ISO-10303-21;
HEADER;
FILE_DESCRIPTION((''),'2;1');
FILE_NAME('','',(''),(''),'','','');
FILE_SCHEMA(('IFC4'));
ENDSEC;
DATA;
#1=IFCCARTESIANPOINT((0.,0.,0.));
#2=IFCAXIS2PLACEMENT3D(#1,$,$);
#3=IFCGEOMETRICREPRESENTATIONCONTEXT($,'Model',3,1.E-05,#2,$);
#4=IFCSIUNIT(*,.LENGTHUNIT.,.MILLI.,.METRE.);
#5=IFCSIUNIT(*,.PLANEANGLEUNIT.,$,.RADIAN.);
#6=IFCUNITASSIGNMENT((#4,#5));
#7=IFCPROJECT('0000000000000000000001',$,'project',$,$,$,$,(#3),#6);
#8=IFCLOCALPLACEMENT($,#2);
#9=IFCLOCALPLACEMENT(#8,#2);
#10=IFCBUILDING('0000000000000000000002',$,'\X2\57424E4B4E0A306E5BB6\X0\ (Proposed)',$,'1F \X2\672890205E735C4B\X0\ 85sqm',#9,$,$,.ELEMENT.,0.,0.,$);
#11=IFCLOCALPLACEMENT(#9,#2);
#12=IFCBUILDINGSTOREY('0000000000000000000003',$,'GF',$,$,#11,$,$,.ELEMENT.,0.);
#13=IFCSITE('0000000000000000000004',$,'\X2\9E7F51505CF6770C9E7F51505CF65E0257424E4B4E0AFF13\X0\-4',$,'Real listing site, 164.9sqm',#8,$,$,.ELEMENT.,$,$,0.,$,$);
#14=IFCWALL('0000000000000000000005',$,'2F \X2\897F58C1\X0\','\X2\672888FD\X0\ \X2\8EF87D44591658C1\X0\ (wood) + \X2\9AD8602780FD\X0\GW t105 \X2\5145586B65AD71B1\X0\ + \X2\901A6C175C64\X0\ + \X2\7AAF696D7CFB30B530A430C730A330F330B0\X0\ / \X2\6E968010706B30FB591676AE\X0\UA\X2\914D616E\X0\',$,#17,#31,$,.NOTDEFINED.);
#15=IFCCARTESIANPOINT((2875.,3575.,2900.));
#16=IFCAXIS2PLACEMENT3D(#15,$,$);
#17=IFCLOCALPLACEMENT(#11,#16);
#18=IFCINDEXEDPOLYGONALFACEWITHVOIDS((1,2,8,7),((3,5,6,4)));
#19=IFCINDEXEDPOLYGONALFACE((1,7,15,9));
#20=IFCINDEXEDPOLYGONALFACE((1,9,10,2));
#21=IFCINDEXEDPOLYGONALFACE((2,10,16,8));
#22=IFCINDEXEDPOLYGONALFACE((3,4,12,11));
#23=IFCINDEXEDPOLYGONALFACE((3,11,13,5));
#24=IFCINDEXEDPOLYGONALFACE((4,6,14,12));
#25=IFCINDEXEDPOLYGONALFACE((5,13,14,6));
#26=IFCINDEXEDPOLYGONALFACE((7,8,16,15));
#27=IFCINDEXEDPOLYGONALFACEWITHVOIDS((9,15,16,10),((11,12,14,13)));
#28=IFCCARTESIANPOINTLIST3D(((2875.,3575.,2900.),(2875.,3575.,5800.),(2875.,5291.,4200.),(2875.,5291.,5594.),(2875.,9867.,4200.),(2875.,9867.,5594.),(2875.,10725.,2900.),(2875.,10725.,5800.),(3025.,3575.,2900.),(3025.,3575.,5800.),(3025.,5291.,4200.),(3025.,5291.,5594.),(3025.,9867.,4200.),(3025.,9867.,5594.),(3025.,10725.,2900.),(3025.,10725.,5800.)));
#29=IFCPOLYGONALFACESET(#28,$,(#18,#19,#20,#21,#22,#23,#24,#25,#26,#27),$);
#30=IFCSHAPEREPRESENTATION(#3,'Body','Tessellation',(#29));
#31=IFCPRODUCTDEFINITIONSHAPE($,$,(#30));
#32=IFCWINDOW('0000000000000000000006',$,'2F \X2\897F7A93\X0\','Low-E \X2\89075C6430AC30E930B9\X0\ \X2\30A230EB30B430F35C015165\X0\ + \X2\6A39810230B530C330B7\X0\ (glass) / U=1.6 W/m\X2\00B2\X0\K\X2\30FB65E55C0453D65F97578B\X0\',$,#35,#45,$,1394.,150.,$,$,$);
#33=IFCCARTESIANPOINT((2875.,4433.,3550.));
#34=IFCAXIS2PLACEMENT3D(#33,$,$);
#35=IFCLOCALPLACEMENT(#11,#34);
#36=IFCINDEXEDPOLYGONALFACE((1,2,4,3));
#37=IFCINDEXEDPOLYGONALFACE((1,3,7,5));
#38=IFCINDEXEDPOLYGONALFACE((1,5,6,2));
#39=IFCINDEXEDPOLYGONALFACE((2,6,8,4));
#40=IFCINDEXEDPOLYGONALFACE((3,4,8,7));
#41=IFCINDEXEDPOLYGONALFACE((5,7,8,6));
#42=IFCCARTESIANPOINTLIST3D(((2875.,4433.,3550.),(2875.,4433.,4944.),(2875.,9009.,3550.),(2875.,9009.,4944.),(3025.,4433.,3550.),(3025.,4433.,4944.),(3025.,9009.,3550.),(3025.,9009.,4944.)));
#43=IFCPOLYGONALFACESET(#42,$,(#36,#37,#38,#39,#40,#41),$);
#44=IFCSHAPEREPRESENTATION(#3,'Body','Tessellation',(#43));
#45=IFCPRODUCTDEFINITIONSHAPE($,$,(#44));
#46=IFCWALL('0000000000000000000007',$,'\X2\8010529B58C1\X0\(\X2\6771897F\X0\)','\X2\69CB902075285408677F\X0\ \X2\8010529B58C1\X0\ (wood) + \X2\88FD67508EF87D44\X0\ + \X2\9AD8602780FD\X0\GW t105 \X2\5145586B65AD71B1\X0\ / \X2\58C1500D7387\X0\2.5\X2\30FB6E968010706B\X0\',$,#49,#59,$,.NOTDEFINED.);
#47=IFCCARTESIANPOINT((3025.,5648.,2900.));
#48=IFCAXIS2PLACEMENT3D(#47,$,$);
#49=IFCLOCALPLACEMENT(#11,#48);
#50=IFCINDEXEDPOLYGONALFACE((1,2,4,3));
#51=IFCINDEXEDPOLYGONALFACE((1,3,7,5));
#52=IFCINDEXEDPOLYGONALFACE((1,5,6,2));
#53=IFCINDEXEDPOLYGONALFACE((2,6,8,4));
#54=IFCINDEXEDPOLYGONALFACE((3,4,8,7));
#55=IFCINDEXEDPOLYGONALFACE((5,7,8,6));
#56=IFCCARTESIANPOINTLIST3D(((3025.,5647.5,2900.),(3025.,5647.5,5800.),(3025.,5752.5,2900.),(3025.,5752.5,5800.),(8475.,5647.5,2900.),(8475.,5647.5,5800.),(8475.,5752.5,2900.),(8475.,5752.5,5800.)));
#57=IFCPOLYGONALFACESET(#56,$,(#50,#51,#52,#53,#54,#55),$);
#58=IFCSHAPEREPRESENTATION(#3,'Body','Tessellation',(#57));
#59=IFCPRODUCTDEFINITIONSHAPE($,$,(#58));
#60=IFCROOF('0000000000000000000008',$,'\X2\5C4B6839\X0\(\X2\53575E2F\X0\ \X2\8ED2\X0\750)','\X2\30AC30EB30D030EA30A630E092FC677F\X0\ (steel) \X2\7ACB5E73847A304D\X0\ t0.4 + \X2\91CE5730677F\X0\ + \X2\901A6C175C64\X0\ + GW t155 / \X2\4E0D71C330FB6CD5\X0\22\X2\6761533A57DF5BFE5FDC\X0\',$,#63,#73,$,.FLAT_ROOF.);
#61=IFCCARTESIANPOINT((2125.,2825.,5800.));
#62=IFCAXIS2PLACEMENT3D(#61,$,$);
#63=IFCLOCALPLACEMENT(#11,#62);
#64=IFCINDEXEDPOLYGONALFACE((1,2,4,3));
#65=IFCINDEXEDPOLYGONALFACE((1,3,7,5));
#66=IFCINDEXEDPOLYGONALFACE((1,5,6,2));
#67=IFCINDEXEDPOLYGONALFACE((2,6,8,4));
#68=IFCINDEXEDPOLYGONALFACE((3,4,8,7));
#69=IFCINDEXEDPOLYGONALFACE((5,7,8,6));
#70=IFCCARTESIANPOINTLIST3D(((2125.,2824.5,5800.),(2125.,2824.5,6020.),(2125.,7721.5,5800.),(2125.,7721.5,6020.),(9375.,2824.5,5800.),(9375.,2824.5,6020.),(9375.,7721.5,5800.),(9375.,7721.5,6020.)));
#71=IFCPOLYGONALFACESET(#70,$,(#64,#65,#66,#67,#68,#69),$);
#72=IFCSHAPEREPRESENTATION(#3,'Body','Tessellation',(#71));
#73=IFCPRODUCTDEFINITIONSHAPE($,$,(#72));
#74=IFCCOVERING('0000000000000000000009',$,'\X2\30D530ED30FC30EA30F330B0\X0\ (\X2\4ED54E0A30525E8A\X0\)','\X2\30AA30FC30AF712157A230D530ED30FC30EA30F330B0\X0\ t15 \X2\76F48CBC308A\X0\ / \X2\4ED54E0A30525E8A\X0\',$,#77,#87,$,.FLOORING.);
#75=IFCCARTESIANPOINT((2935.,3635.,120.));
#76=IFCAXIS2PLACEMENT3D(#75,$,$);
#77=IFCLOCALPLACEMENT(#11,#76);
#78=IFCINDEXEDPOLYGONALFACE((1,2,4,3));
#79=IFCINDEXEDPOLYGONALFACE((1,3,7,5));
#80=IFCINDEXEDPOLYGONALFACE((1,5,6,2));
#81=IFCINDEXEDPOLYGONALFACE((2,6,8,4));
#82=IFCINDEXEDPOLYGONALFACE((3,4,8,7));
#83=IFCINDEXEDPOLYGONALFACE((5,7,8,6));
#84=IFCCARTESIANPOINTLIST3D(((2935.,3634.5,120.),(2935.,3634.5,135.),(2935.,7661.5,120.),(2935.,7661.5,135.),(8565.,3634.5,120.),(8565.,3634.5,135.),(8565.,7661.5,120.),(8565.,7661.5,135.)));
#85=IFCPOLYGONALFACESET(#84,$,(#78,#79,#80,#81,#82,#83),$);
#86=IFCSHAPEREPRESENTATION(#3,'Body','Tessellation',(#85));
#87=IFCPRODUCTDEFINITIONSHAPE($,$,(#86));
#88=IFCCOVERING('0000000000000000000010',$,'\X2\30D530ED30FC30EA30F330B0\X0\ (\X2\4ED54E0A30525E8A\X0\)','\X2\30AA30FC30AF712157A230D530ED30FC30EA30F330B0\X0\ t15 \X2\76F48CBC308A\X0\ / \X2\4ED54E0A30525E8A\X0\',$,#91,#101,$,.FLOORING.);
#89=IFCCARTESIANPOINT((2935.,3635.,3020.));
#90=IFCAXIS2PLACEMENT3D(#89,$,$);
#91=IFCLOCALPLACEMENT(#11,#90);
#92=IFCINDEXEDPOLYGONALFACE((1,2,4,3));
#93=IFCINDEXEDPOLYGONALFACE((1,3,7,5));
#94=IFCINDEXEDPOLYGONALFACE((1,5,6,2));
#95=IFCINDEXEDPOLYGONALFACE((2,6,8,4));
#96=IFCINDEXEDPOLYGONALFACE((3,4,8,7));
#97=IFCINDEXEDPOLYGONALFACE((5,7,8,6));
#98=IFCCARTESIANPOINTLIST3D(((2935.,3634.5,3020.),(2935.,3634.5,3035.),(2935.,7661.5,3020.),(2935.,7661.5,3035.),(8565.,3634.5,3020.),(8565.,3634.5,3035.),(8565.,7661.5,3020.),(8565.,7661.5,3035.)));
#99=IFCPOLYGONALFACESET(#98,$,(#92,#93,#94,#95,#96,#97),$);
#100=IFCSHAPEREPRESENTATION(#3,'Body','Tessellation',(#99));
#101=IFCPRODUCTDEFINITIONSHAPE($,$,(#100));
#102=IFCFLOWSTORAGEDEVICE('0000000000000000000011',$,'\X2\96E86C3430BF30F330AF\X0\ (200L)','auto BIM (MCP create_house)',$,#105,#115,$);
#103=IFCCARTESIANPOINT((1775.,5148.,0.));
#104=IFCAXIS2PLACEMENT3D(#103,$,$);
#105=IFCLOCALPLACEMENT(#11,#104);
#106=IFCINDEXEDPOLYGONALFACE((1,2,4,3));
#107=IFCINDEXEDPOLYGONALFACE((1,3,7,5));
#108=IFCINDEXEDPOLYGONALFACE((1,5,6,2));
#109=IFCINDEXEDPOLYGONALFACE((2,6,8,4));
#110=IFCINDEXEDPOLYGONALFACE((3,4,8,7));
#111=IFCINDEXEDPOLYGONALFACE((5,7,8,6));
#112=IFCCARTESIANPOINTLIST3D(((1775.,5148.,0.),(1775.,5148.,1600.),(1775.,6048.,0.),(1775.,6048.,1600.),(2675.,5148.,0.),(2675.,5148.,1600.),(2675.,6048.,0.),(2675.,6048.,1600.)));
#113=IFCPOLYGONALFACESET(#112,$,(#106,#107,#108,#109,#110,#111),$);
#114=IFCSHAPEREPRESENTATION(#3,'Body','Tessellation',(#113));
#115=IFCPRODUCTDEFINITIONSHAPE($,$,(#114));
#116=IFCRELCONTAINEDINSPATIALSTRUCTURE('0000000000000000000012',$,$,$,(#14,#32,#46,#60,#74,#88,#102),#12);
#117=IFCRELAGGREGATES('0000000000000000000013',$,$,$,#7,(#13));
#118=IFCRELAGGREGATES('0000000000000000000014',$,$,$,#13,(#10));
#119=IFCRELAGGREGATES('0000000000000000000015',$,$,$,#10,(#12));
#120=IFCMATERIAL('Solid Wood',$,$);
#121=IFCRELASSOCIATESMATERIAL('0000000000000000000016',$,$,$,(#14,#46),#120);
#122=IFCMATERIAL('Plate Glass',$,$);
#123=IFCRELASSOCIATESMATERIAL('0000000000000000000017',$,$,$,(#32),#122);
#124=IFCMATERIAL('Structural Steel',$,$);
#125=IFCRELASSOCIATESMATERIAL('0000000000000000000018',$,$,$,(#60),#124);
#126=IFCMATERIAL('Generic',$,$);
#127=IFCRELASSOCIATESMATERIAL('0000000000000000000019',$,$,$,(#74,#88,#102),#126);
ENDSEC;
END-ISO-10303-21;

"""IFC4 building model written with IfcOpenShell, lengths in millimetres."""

from ifc_helpers import new_model, si_unit, frame, frame_2d, origin, place, context, project, spatial, rectangle, extrude, material, element, fill, save


model = new_model("IFC4")

# Units and contexts
model_context = context("Model", 3, precision=1e-05, world=origin())
ifc_project = project(units=[si_unit("LENGTHUNIT", "METRE", prefix="MILLI"), si_unit("PLANEANGLEUNIT", "RADIAN")], contexts=[model_context])

# Site, building, storey
site_placement = place(None, origin())
site = spatial("IfcSite", under=ifc_project, at=site_placement, Name="鹿児島県鹿児島市坂之上３-4", ObjectType="Real listing site, 164.9sqm", CompositionType="ELEMENT", RefElevation=0.0)
building_placement = place(site_placement, origin())
building = spatial("IfcBuilding", under=site, at=building_placement, Name="坂之上の家 (Proposed)", ObjectType="1F 木造平屋 85sqm", CompositionType="ELEMENT", ElevationOfRefHeight=0.0, ElevationOfTerrain=0.0)
storey_placement = place(building_placement, origin())
storey = spatial("IfcBuildingStorey", under=building, at=storey_placement, Name="GF", CompositionType="ELEMENT", Elevation=0.0)

# Shared definitions
ifc_material_1 = material(Name="Solid Wood")
ifc_material_2 = material(Name="Generic")

# Shared definitions
ifc_material_3 = material(Name="Plate Glass")

# Wall, opening, window
wall_1_placement = place(storey_placement, frame((2875.0, 3575.0, 2900.0)))
wall_1 = element("IfcWall", 1, at=wall_1_placement, inside=storey, material=ifc_material_1, Name="2F 西壁", Description="木製 軸組外壁 (wood) + 高性能GW t105 充填断熱 + 通気層 + 窯業系サイディング / 準耐火・外皮UA配慮", PredefinedType="NOTDEFINED", context=model_context, shape_type="SweptSolid", body=[
    extrude(rectangle(XDim=150.0, YDim=7150.0, at=frame_2d((75.0, 3575.0))), frame((2875.0, 3575.0, 2900.0)), (0.0, 0.0, 1.0), 2900.0),
])
opening_1_placement = place(storey_placement, frame((2875.0, 4433.0, 3550.0)))
opening_1 = element("IfcOpeningElement", 2, at=opening_1_placement, cuts=wall_1, PredefinedType="NOTDEFINED", context=model_context, shape_type="SweptSolid", body=[
    extrude(rectangle(XDim=150.0, YDim=4576.0, at=frame_2d((75.0, 2288.0))), frame((2875.0, 4433.0, 3550.0)), (0.0, 0.0, 1.0), 1394.0),
])
window_1_placement = place(storey_placement, frame((2875.0, 4433.0, 3550.0)))
window_1 = element("IfcWindow", 3, at=window_1_placement, inside=storey, material=ifc_material_3, Name="2F 西窓", Description="Low-E 複層ガラス アルゴン封入 + 樹脂サッシ (glass) / U=1.6 W/m²K・日射取得型", OverallHeight=1394.0, OverallWidth=150.0, context=model_context, shape_type="SweptSolid", body=[
    extrude(rectangle(XDim=150.0, YDim=4576.0, at=frame_2d((75.0, 2288.0))), frame((2875.0, 4433.0, 3550.0)), (0.0, 0.0, 1.0), 1394.0),
])
fill(opening_1, window_1)

# Wall
wall_2_placement = place(storey_placement, frame((3025.0, 5648.0, 2900.0)))
element("IfcWall", 4, at=wall_2_placement, inside=storey, material=ifc_material_1, Name="耐力壁(東西)", Description="構造用合板 耐力壁 (wood) + 製材軸組 + 高性能GW t105 充填断熱 / 壁倍率2.5・準耐火", PredefinedType="NOTDEFINED", context=model_context, shape_type="SweptSolid", body=[
    extrude(rectangle(XDim=5450.0, YDim=105.0, at=frame_2d((2725.0, 52.0))), frame((3025.0, 5648.0, 2900.0)), (0.0, 0.0, 1.0), 2900.0),
])

# Roof
ifc_material_4 = material(Name="Structural Steel")
for number, where, name in (
    (5, (2125.0, 2825.0, 5800.0), "屋根(南帯 軒750)"),
):
    element("IfcRoof", number, at=place(storey_placement, frame(where)), inside=storey, material=ifc_material_4, Name=name, Description="ガルバリウム鋼板 (steel) 立平葺き t0.4 + 野地板 + 通気層 + GW t155 / 不燃・法22条区域対応", PredefinedType="FLAT_ROOF", context=model_context, shape_type="SweptSolid", body=[
        extrude(rectangle(XDim=7250.0, YDim=4897.0, at=frame_2d((3625.0, 2448.0))), frame((2125.0, 2825.0, 5800.0)), (0.0, 0.0, 1.0), 220.0),
    ])

# Coverings
covering_1_placement = place(storey_placement, frame((2935.0, 3635.0, 120.0)))
element("IfcCovering", 6, at=covering_1_placement, inside=storey, material=ifc_material_2, Name="フローリング (仕上げ床)", Description="オーク無垢フローリング t15 直貼り / 仕上げ床", PredefinedType="FLOORING", context=model_context, shape_type="SweptSolid", body=[
    extrude(rectangle(XDim=5630.0, YDim=4027.0, at=frame_2d((2815.0, 2013.0))), frame((2935.0, 3635.0, 120.0)), (0.0, 0.0, 1.0), 15.0),
])
covering_2_placement = place(storey_placement, frame((2935.0, 3635.0, 3020.0)))
element("IfcCovering", 7, at=covering_2_placement, inside=storey, material=ifc_material_2, Name="フローリング (仕上げ床)", Description="オーク無垢フローリング t15 直貼り / 仕上げ床", PredefinedType="FLOORING", context=model_context, shape_type="SweptSolid", body=[
    extrude(rectangle(XDim=5630.0, YDim=4027.0, at=frame_2d((2815.0, 2013.0))), frame((2935.0, 3635.0, 3020.0)), (0.0, 0.0, 1.0), 15.0),
])

# Flow storage device
flow_storage_device_placement = place(storey_placement, frame((1775.0, 5148.0, 0.0)))
element("IfcFlowStorageDevice", 8, at=flow_storage_device_placement, inside=storey, material=ifc_material_2, Name="雨水タンク (200L)", Description="auto BIM (MCP create_house)", context=model_context, shape_type="SweptSolid", body=[
    extrude(rectangle(XDim=900.0, YDim=900.0, at=frame_2d((450.0, 450.0))), frame((1775.0, 5148.0, 0.0)), (0.0, 0.0, 1.0), 1600.0),
])

save(model, "model.ifc")
